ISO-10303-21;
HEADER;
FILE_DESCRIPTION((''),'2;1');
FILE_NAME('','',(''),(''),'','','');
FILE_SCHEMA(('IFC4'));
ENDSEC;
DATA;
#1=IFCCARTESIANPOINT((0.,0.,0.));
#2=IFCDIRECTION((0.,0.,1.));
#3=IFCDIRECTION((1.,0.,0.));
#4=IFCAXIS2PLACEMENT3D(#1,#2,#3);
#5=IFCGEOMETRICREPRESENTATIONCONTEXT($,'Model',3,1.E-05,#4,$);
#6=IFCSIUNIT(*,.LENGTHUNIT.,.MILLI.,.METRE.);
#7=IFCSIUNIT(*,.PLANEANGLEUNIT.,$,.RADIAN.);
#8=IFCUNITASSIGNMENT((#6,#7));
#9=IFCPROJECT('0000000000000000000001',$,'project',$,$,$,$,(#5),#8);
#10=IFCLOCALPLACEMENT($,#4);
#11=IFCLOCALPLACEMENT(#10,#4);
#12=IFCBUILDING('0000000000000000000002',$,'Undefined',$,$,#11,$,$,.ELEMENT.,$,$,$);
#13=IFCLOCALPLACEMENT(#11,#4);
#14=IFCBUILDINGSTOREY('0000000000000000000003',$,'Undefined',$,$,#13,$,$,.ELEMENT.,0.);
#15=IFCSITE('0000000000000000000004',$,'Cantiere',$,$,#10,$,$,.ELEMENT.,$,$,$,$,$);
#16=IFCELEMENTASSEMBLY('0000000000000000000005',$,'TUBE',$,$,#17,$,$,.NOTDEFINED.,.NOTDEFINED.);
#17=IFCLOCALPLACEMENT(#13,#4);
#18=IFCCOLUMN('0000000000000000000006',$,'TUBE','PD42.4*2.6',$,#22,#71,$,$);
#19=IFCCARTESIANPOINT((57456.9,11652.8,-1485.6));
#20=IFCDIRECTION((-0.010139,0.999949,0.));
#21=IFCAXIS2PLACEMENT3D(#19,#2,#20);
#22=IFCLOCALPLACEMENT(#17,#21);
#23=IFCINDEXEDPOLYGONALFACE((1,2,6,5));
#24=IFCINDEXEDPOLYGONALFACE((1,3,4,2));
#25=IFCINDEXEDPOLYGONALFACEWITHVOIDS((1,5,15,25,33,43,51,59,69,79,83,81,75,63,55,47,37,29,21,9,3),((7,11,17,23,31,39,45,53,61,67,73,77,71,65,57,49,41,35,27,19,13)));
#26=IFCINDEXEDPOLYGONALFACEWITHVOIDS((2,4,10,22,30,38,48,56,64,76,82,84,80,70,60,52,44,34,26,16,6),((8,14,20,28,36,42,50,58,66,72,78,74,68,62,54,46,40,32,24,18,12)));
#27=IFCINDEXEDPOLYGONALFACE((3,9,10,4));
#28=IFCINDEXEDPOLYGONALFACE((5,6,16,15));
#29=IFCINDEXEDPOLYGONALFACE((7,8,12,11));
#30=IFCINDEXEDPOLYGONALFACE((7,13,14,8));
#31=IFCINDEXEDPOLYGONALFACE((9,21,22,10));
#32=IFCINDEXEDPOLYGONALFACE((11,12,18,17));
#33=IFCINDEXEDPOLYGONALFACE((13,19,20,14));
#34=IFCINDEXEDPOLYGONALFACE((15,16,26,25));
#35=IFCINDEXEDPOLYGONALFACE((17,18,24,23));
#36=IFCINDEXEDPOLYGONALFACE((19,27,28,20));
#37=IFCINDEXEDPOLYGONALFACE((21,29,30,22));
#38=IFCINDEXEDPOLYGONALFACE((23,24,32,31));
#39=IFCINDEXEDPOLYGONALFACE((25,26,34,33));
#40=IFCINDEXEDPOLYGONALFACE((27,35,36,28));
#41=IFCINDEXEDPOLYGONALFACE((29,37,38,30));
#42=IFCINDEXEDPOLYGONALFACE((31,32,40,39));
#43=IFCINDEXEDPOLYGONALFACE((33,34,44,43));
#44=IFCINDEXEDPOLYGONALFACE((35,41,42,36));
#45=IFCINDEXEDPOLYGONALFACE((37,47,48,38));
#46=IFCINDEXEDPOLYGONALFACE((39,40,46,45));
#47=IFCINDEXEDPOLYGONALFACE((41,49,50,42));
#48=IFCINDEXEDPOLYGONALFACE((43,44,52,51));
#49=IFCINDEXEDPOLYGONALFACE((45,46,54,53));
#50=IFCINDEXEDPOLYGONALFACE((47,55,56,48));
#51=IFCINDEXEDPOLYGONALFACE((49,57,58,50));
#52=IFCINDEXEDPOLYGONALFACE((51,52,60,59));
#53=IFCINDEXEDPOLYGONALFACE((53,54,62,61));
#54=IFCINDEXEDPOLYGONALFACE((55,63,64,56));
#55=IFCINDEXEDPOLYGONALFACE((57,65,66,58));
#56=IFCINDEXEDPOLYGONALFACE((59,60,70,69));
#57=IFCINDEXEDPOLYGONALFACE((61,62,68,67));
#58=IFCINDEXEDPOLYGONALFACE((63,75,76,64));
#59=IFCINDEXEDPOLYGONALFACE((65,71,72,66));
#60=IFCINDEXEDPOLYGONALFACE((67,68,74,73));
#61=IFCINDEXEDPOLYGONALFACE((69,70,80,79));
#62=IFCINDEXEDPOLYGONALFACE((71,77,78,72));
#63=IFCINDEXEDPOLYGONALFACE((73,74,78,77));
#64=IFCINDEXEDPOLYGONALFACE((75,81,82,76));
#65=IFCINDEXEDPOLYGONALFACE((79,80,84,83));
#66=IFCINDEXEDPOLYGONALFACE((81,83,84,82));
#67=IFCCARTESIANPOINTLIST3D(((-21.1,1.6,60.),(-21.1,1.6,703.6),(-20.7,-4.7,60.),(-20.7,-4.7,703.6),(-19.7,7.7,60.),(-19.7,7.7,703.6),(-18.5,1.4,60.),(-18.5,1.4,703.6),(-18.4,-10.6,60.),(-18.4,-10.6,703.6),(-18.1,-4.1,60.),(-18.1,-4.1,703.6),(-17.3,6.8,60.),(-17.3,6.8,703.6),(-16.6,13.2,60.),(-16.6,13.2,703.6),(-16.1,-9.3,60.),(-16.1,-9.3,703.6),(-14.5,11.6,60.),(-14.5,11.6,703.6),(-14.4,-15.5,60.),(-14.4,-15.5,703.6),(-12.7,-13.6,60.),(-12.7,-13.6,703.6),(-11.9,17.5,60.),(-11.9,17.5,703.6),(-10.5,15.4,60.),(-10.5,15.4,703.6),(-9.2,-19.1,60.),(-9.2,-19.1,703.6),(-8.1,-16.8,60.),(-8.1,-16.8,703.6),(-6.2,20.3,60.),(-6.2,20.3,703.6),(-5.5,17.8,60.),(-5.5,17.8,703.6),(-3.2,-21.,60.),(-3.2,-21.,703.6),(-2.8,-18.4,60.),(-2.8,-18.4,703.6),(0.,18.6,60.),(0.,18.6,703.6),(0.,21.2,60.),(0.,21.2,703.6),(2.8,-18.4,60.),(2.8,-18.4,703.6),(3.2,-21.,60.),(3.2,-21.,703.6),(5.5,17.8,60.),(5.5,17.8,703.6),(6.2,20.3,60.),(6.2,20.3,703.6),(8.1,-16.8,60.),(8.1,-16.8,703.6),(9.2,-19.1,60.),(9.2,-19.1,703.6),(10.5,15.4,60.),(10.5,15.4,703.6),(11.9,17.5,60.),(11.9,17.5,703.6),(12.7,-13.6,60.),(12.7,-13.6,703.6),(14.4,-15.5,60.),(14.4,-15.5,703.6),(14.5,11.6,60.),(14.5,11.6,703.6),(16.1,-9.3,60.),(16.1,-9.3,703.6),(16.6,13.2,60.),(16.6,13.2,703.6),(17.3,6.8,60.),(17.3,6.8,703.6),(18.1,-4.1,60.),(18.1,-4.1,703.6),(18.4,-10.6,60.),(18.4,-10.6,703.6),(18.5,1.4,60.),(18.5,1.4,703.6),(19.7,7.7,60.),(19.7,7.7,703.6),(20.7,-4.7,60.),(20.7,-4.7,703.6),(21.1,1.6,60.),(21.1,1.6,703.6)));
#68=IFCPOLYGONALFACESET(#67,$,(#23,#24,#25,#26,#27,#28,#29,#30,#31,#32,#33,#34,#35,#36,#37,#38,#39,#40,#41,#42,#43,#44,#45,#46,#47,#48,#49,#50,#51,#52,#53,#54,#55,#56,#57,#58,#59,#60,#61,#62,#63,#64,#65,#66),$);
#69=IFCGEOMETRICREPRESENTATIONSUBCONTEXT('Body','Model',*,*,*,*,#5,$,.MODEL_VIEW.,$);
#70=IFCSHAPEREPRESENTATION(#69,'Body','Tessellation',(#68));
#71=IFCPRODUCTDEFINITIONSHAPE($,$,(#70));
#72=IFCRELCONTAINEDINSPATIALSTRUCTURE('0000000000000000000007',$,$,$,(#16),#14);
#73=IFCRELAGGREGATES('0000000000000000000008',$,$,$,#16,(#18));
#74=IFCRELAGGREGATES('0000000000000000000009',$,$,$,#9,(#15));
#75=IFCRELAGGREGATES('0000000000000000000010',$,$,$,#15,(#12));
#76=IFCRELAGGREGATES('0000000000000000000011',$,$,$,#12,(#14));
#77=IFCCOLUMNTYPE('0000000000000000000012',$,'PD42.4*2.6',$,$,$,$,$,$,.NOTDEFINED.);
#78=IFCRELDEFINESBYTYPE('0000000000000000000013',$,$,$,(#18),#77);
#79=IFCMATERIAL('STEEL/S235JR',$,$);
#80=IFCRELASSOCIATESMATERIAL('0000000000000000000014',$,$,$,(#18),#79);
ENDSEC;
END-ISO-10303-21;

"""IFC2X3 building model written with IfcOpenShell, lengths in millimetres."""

from ifc_helpers import new_model, si_unit, frame, origin_with_axes, origin_2d_with_axis, place, context, subcontext, project, spatial, hollow_circle, extrude, clip, halfspace, material, type_object, element, aggregate, save


model = new_model("IFC2X3")

# Units and contexts
model_context = context("Model", 3, precision=1e-05, world=origin_with_axes())
body_context = subcontext(model_context, "Body", "Model", "MODEL_VIEW")
ifc_project = project(units=[si_unit("LENGTHUNIT", "METRE", prefix="MILLI"), si_unit("PLANEANGLEUNIT", "RADIAN")], contexts=[model_context])

# Site, building, storey
site_placement = place(None, origin_with_axes())
site = spatial("IfcSite", under=ifc_project, at=site_placement, Name="Cantiere", CompositionType="ELEMENT")
building_placement = place(site_placement, origin_with_axes())
building = spatial("IfcBuilding", under=site, at=building_placement, Name="Undefined", CompositionType="ELEMENT")
storey_placement = place(building_placement, origin_with_axes())
storey = spatial("IfcBuildingStorey", under=building, at=storey_placement, Name="Undefined", CompositionType="ELEMENT", Elevation=0.0)

# Element assembly, column
assembly_1_placement = place(storey_placement, origin_with_axes())
assembly_1 = element("IfcElementAssembly", 1, at=assembly_1_placement, inside=storey, Name="TUBE", AssemblyPlace="NOTDEFINED", PredefinedType="NOTDEFINED")
ifc_material_1 = material(Name="STEEL/S235JR")
column_type = type_object("IfcColumnType", Name="PD42.4*2.6", PredefinedType="NOTDEFINED")
column_placement = place(assembly_1_placement, frame((57456.9, 11652.8, -1485.6), z_axis=(0.0, 0.0, 1.0), x_axis=(-0.010139, 0.999949, 0.0)))
column = element("IfcColumn", 2, at=column_placement, type_object=column_type, material=ifc_material_1, Name="TUBE", Description="PD42.4*2.6", context=body_context, shape_type="Clipping", body=[
    clip(clip(extrude(hollow_circle(Radius=21.2, WallThickness=2.6, at=origin_2d_with_axis()), frame((0.0, 0.0, 753.6), z_axis=(0.0, 0.000001, -1.0), x_axis=(0.0, 1.0, 0.0)), (0.0, 0.0, 1.0), 753.6), halfspace(frame((0.0, 0.0, 703.6), z_axis=(0.0, 0.0, 1.0), x_axis=(-1.0, 0.0, 0.0)), False)), halfspace(frame((0.0, 0.0, 60.0), z_axis=(0.0, 0.000001, -1.0), x_axis=(-1.0, 0.0, 0.0)), False)),
])

aggregate(assembly_1, [column])

save(model, "model.ifc")
